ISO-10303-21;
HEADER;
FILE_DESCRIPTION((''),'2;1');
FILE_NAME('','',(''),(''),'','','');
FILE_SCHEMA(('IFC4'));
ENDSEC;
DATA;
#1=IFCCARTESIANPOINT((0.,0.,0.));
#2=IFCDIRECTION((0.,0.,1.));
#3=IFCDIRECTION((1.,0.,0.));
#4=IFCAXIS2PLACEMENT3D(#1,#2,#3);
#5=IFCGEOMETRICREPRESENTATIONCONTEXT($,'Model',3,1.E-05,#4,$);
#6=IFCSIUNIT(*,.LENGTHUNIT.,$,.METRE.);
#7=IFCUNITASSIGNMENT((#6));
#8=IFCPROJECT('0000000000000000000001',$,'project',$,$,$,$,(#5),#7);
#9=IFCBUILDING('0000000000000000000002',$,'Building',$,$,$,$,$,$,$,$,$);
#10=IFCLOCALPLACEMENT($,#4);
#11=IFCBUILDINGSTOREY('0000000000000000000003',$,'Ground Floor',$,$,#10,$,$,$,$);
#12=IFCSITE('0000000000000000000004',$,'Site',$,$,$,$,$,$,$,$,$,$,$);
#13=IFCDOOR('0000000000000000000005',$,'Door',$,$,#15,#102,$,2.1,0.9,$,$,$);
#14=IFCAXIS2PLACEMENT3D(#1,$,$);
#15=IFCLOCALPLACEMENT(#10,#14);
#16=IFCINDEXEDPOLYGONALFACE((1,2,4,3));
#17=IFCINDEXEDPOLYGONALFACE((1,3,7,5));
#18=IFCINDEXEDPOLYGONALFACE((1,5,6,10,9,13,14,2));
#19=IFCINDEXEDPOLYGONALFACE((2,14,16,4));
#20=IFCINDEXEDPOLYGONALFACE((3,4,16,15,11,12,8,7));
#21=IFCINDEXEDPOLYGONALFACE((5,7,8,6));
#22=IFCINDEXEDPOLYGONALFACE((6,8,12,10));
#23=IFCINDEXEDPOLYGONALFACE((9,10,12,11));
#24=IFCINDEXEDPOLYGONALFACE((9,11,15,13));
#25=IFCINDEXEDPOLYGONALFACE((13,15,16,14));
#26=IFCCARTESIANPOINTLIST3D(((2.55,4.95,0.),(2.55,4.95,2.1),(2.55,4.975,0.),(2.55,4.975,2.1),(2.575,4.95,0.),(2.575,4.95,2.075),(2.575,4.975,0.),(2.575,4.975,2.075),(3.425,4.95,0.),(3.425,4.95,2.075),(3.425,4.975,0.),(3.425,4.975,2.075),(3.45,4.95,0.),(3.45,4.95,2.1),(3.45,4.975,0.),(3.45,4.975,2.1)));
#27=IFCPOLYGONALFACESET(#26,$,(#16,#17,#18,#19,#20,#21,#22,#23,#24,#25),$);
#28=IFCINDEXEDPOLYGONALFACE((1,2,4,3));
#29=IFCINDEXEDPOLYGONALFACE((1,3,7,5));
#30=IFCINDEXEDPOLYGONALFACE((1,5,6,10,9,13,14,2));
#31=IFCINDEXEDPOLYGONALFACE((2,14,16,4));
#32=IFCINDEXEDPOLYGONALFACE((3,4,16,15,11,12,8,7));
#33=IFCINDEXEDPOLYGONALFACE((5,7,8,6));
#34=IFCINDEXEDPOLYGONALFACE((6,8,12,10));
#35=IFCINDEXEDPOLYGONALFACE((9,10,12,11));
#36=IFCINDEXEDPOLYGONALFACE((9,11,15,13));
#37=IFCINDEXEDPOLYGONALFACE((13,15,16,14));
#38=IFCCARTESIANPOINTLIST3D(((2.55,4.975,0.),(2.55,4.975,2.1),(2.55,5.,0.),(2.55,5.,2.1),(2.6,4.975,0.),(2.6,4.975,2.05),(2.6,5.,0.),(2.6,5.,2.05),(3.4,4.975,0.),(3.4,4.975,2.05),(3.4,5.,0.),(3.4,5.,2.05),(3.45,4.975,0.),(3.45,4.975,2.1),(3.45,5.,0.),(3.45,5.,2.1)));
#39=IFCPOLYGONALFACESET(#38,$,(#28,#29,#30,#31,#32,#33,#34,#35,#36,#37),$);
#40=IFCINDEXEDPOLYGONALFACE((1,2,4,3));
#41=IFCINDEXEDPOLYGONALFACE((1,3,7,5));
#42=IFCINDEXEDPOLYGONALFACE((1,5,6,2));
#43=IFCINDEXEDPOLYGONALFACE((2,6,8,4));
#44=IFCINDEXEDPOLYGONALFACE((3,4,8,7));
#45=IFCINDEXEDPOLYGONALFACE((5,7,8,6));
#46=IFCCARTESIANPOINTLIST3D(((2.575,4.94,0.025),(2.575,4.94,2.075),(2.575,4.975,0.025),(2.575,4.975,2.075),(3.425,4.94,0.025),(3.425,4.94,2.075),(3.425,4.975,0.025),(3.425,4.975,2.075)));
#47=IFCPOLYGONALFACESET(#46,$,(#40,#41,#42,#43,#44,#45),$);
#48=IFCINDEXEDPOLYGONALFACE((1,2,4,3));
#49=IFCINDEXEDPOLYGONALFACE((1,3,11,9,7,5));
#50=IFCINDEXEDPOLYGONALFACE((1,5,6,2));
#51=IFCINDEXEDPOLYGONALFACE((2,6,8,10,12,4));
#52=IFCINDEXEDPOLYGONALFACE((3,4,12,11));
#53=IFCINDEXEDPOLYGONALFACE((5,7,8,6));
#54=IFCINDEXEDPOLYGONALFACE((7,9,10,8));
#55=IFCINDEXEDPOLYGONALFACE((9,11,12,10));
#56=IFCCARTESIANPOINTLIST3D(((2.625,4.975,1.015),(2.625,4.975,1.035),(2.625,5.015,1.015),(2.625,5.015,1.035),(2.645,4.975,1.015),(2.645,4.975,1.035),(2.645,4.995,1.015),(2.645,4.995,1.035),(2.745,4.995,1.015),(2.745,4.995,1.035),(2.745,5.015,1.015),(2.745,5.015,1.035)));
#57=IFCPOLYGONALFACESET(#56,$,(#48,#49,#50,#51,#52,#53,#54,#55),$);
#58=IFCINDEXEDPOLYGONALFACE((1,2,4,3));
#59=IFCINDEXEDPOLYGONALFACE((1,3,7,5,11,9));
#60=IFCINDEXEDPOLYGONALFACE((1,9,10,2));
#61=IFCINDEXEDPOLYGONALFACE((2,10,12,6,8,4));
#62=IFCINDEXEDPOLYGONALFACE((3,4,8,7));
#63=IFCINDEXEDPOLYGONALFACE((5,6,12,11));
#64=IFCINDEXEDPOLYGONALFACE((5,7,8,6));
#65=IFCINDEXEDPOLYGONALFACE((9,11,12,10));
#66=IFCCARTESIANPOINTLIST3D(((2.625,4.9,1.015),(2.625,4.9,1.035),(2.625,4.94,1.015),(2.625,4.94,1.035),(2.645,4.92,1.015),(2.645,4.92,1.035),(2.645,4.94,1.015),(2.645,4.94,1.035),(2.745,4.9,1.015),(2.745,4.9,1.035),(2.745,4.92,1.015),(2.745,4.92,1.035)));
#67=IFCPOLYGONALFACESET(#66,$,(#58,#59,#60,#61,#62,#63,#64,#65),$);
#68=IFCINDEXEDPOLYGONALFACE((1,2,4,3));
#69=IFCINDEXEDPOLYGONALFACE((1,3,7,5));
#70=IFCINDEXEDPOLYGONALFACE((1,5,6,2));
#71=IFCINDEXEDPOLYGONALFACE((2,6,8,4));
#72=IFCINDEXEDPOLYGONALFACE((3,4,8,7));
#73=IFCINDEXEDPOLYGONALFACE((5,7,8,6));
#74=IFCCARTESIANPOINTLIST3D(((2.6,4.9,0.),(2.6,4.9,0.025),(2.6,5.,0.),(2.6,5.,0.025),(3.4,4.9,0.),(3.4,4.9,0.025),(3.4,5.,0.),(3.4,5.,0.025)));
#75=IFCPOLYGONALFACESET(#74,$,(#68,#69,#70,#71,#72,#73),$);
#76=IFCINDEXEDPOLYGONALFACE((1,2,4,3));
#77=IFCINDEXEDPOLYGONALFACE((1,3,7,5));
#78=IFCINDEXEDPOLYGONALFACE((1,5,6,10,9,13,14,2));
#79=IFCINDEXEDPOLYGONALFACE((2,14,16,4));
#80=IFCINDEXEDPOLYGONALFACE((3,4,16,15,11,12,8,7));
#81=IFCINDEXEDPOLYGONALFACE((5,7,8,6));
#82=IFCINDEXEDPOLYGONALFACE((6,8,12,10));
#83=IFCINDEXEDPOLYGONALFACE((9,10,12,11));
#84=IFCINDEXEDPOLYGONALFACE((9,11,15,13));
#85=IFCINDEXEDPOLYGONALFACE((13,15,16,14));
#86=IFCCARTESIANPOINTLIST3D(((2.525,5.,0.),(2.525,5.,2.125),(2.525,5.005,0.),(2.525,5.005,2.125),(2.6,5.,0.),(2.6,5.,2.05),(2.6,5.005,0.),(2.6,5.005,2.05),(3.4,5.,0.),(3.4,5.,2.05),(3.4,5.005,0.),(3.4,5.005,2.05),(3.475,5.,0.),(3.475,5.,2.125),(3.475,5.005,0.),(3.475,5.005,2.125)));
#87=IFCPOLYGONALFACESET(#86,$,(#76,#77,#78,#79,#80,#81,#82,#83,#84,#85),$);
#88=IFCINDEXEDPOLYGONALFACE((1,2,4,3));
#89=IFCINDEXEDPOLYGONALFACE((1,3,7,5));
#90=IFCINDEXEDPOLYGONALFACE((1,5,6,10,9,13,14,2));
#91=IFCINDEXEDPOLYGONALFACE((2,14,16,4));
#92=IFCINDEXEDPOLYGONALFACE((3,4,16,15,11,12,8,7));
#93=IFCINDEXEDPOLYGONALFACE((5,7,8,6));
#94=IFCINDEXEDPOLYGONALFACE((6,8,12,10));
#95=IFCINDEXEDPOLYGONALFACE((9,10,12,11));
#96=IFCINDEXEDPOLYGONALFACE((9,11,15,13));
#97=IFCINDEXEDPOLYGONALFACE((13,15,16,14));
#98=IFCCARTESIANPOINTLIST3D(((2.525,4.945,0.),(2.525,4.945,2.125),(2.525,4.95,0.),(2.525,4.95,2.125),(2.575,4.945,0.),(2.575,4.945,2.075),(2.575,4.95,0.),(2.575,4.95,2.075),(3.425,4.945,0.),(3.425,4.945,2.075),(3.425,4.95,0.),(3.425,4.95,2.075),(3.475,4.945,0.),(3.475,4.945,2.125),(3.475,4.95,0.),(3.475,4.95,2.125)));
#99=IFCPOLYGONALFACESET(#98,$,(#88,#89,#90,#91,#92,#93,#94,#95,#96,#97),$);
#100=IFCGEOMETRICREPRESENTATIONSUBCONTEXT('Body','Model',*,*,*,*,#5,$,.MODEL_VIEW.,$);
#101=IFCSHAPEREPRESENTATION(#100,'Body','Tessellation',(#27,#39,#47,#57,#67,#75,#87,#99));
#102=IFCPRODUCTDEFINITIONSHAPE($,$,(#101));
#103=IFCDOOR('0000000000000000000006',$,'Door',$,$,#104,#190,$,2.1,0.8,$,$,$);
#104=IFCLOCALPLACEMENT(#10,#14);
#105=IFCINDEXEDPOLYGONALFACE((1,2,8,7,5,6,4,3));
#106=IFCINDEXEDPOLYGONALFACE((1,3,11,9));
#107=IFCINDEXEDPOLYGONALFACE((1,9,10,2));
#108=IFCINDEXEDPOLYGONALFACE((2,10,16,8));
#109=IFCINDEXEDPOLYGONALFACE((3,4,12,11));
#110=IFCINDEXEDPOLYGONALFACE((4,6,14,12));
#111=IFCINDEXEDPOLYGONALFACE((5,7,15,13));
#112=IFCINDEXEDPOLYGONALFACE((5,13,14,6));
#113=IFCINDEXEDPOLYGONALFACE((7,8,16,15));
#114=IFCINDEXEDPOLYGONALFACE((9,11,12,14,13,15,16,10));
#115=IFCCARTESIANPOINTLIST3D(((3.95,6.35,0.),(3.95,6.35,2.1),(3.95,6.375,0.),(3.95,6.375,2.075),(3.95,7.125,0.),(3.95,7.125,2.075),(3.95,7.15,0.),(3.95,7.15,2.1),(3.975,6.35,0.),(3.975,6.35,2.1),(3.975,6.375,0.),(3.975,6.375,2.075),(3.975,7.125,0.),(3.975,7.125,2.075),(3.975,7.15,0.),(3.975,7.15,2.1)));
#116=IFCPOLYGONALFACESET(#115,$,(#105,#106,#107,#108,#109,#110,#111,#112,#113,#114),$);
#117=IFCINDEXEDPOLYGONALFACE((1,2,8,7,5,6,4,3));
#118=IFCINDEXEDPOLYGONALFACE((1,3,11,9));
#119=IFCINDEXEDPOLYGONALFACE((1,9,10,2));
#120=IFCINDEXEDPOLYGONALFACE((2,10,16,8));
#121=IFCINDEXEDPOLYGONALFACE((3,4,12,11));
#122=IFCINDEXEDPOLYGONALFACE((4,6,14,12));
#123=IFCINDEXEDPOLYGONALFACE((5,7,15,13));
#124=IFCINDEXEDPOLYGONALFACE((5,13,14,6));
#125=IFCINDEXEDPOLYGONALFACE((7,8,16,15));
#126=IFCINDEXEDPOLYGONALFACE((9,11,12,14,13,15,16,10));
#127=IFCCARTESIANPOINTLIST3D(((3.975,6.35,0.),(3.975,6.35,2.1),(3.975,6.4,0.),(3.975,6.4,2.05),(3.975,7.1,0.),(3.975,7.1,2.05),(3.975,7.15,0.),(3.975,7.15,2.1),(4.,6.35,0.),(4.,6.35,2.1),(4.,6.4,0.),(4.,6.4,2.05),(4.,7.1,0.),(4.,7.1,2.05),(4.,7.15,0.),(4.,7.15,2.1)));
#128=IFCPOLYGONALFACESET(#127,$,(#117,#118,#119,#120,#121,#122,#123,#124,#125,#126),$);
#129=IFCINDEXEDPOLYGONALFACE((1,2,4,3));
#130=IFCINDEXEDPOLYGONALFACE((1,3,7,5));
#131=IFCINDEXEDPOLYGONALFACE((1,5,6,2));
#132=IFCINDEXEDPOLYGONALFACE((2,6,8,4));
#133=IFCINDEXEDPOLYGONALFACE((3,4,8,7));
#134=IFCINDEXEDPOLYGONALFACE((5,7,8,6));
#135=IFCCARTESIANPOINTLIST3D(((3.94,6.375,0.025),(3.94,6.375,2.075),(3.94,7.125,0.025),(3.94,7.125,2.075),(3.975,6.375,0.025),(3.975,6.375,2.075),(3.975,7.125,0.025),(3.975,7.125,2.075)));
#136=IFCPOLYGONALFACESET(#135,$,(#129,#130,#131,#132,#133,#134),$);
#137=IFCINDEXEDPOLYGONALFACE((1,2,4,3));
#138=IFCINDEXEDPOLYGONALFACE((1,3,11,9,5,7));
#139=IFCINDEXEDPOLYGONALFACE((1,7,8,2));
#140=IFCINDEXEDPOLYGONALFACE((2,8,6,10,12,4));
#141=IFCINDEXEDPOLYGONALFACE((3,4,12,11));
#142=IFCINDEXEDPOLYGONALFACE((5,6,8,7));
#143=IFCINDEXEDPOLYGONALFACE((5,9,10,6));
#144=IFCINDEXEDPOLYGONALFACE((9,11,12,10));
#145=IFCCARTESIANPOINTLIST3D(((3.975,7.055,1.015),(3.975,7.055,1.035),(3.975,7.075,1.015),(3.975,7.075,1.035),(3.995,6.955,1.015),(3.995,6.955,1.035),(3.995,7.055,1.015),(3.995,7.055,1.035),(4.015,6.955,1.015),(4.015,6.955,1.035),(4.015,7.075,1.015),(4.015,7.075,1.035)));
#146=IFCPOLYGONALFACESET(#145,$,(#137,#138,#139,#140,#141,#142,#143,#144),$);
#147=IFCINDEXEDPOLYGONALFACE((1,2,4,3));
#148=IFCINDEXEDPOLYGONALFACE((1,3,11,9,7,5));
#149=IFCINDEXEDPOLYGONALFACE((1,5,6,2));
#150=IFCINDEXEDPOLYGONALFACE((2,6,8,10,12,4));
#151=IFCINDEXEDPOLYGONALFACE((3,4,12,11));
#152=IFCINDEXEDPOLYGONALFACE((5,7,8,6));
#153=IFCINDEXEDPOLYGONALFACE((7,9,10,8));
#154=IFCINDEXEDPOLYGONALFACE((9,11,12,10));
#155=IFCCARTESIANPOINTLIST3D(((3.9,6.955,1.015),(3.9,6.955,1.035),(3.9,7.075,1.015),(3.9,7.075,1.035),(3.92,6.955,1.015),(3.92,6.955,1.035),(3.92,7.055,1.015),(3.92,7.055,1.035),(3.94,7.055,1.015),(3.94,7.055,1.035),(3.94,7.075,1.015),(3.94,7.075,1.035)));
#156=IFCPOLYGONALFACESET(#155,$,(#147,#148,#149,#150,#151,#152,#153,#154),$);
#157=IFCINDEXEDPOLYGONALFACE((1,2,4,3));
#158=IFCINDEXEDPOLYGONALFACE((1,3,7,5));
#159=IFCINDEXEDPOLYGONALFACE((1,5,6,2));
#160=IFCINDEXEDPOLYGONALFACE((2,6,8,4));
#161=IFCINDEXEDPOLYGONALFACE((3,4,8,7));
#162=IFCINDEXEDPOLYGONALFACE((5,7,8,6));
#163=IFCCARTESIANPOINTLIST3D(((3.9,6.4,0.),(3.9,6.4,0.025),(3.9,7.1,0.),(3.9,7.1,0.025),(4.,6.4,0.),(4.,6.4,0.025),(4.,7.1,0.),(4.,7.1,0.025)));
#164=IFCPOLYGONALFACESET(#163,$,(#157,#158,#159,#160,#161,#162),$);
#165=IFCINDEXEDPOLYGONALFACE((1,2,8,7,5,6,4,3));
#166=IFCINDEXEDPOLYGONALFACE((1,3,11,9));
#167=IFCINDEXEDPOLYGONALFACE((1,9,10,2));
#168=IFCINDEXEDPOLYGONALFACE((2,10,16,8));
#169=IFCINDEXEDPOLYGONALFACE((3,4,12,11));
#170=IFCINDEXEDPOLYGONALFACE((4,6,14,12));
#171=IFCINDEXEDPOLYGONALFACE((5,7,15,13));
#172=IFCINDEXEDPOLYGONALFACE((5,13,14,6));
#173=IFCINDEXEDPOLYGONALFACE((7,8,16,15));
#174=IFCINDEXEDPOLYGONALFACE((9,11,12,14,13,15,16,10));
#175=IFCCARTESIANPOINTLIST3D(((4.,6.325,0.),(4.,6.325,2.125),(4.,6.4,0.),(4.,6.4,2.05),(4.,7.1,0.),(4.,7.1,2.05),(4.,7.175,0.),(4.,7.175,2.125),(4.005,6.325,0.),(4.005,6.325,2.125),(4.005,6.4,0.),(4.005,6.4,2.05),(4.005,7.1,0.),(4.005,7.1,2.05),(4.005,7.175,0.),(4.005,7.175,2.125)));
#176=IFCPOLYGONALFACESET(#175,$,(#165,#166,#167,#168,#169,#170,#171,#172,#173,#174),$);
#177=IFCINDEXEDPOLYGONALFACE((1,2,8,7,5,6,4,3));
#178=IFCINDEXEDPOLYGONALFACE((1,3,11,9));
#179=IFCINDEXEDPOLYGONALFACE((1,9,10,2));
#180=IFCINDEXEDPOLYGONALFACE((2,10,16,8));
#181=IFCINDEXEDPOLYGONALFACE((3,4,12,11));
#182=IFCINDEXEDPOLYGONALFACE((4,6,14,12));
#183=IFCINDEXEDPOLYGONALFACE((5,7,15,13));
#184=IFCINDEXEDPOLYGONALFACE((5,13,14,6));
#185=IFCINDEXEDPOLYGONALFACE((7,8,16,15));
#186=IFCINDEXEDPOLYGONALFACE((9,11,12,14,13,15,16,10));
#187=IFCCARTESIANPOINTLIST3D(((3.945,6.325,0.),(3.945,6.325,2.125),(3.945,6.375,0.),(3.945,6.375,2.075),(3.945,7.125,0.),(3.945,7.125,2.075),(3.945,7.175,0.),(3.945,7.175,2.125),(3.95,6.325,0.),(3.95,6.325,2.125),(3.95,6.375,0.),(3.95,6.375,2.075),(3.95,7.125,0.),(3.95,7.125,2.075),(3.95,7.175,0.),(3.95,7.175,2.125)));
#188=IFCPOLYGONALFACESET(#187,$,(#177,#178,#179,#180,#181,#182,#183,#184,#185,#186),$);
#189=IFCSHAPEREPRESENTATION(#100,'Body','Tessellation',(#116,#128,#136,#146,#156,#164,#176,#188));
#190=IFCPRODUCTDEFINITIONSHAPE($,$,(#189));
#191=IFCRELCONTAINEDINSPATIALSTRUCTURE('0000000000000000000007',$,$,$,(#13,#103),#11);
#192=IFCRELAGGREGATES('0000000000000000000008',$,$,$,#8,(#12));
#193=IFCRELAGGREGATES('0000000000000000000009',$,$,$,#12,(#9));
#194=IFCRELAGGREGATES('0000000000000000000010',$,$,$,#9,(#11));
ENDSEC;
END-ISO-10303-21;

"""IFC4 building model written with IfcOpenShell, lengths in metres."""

from ifc_helpers import new_model, si_unit, frame, origin_with_axes, place, context, subcontext, project, spatial, line, indexed_curve, outline, extrude, element, save


model = new_model("IFC4")

# Units and contexts
model_context = context("Model", 3, precision=1e-05, world=origin_with_axes())
body_context = subcontext(model_context, "Body", "Model", "MODEL_VIEW")
ifc_project = project(units=[si_unit("LENGTHUNIT", "METRE")], contexts=[model_context])

# Site, building, storey
site = spatial("IfcSite", under=ifc_project, Name="Site")
building = spatial("IfcBuilding", under=site, Name="Building")
storey_placement = place(None, origin_with_axes())
storey = spatial("IfcBuildingStorey", under=building, at=storey_placement, Name="Ground Floor")

# Doors
door_1_placement = place(storey_placement, frame((3.45, 5.0, 0.0), z_axis=(0.0, 0.0, 1.0), x_axis=(-1.0, 0.0, 0.0)))
element("IfcDoor", 1, at=door_1_placement, inside=storey, Name="Door", OverallHeight=2.1, OverallWidth=0.9, context=body_context, shape_type="SweptSolid", body=[
    extrude(outline(indexed_curve([(0.0, 0.0), (0.0, 2.1), (0.9, 2.1), (0.9, 0.0), (0.875, 0.0), (0.875, 2.075), (0.025, 2.075), (0.025, 0.0)], segments=[line(1, 2, 3, 4, 5, 6, 7, 8, 1)])), frame((0.0, 0.025, 0.0), z_axis=(0.0, -1.0, 0.0), x_axis=(1.0, 0.0, 0.0)), (0.0, 0.0, -1.0), 0.025),
    extrude(outline(indexed_curve([(0.0, 0.0), (0.0, 2.1), (0.9, 2.1), (0.9, 0.0), (0.85, 0.0), (0.85, 2.05), (0.05, 2.05), (0.05, 0.0)], segments=[line(1, 2, 3, 4, 5, 6, 7, 8, 1)])), frame((0.0, 0.0, 0.0), z_axis=(0.0, -1.0, 0.0), x_axis=(1.0, 0.0, 0.0)), (0.0, 0.0, -1.0), 0.025),
    extrude(outline(indexed_curve([(0.0, 0.0), (0.85, 0.0), (0.85, 0.035), (0.0, 0.035)], segments=[line(1, 2, 3, 4, 1)])), frame((0.025, 0.025, 0.025), z_axis=(0.0, 0.0, 1.0), x_axis=(1.0, 0.0, 0.0)), (0.0, 0.0, 1.0), 2.05),
    extrude(outline(indexed_curve([(0.0, 0.0), (0.0, -0.04), (-0.12, -0.04), (-0.12, -0.02), (-0.02, -0.02), (-0.02, 0.0)], segments=[line(1, 2, 3, 4, 5, 6, 1)])), frame((0.825, 0.025, 1.015), z_axis=(0.0, 0.0, 1.0), x_axis=(1.0, 0.0, 0.0)), (0.0, 0.0, 1.0), 0.02),
    extrude(outline(indexed_curve([(0.0, 0.0), (0.0, 0.04), (-0.12, 0.04), (-0.12, 0.02), (-0.02, 0.02), (-0.02, 0.0)], segments=[line(1, 2, 3, 4, 5, 6, 1)])), frame((0.825, 0.06, 1.015), z_axis=(0.0, 0.0, 1.0), x_axis=(1.0, 0.0, 0.0)), (0.0, 0.0, 1.0), 0.02),
    extrude(outline(indexed_curve([(0.0, 0.0), (0.8, 0.0), (0.8, 0.1), (0.0, 0.1)], segments=[line(1, 2, 3, 4, 1)])), frame((0.05, 0.0, 0.0), z_axis=(0.0, 0.0, 1.0), x_axis=(1.0, 0.0, 0.0)), (0.0, 0.0, 1.0), 0.025),
    extrude(outline(indexed_curve([(0.0, 0.0), (0.0, 2.125), (0.95, 2.125), (0.95, 0.0), (0.875, 0.0), (0.875, 2.05), (0.075, 2.05), (0.075, 0.0)], segments=[line(1, 2, 3, 4, 5, 6, 7, 8, 1)])), frame((-0.025, -0.005, 0.0), z_axis=(0.0, -1.0, 0.0), x_axis=(1.0, 0.0, 0.0)), (0.0, 0.0, -1.0), 0.005),
    extrude(outline(indexed_curve([(0.0, 0.0), (0.0, 2.125), (0.95, 2.125), (0.95, 0.0), (0.9, 0.0), (0.9, 2.075), (0.05, 2.075), (0.05, 0.0)], segments=[line(1, 2, 3, 4, 5, 6, 7, 8, 1)])), frame((-0.025, 0.05, 0.0), z_axis=(0.0, -1.0, 0.0), x_axis=(1.0, 0.0, 0.0)), (0.0, 0.0, -1.0), 0.005),
])
door_2_placement = place(storey_placement, frame((4.0, 6.35, 0.0), z_axis=(0.0, 0.0, 1.0), x_axis=(0.0, 1.0, 0.0)))
element("IfcDoor", 2, at=door_2_placement, inside=storey, Name="Door", OverallHeight=2.1, OverallWidth=0.8, context=body_context, shape_type="SweptSolid", body=[
    extrude(outline(indexed_curve([(0.0, 0.0), (0.0, 2.1), (0.8, 2.1), (0.8, 0.0), (0.775, 0.0), (0.775, 2.075), (0.025, 2.075), (0.025, 0.0)], segments=[line(1, 2, 3, 4, 5, 6, 7, 8, 1)])), frame((0.0, 0.025, 0.0), z_axis=(0.0, -1.0, 0.0), x_axis=(1.0, 0.0, 0.0)), (0.0, 0.0, -1.0), 0.025),
    extrude(outline(indexed_curve([(0.0, 0.0), (0.0, 2.1), (0.8, 2.1), (0.8, 0.0), (0.75, 0.0), (0.75, 2.05), (0.05, 2.05), (0.05, 0.0)], segments=[line(1, 2, 3, 4, 5, 6, 7, 8, 1)])), frame((0.0, 0.0, 0.0), z_axis=(0.0, -1.0, 0.0), x_axis=(1.0, 0.0, 0.0)), (0.0, 0.0, -1.0), 0.025),
    extrude(outline(indexed_curve([(0.0, 0.0), (0.75, 0.0), (0.75, 0.035), (0.0, 0.035)], segments=[line(1, 2, 3, 4, 1)])), frame((0.025, 0.025, 0.025), z_axis=(0.0, 0.0, 1.0), x_axis=(1.0, 0.0, 0.0)), (0.0, 0.0, 1.0), 2.05),
    extrude(outline(indexed_curve([(0.0, 0.0), (0.0, -0.04), (-0.12, -0.04), (-0.12, -0.02), (-0.02, -0.02), (-0.02, 0.0)], segments=[line(1, 2, 3, 4, 5, 6, 1)])), frame((0.725, 0.025, 1.015), z_axis=(0.0, 0.0, 1.0), x_axis=(1.0, 0.0, 0.0)), (0.0, 0.0, 1.0), 0.02),
    extrude(outline(indexed_curve([(0.0, 0.0), (0.0, 0.04), (-0.12, 0.04), (-0.12, 0.02), (-0.02, 0.02), (-0.02, 0.0)], segments=[line(1, 2, 3, 4, 5, 6, 1)])), frame((0.725, 0.06, 1.015), z_axis=(0.0, 0.0, 1.0), x_axis=(1.0, 0.0, 0.0)), (0.0, 0.0, 1.0), 0.02),
    extrude(outline(indexed_curve([(0.0, 0.0), (0.7, 0.0), (0.7, 0.1), (0.0, 0.1)], segments=[line(1, 2, 3, 4, 1)])), frame((0.05, 0.0, 0.0), z_axis=(0.0, 0.0, 1.0), x_axis=(1.0, 0.0, 0.0)), (0.0, 0.0, 1.0), 0.025),
    extrude(outline(indexed_curve([(0.0, 0.0), (0.0, 2.125), (0.85, 2.125), (0.85, 0.0), (0.775, 0.0), (0.775, 2.05), (0.075, 2.05), (0.075, 0.0)], segments=[line(1, 2, 3, 4, 5, 6, 7, 8, 1)])), frame((-0.025, -0.005, 0.0), z_axis=(0.0, -1.0, 0.0), x_axis=(1.0, 0.0, 0.0)), (0.0, 0.0, -1.0), 0.005),
    extrude(outline(indexed_curve([(0.0, 0.0), (0.0, 2.125), (0.85, 2.125), (0.85, 0.0), (0.8, 0.0), (0.8, 2.075), (0.05, 2.075), (0.05, 0.0)], segments=[line(1, 2, 3, 4, 5, 6, 7, 8, 1)])), frame((-0.025, 0.05, 0.0), z_axis=(0.0, -1.0, 0.0), x_axis=(1.0, 0.0, 0.0)), (0.0, 0.0, -1.0), 0.005),
])

save(model, "model.ifc")
